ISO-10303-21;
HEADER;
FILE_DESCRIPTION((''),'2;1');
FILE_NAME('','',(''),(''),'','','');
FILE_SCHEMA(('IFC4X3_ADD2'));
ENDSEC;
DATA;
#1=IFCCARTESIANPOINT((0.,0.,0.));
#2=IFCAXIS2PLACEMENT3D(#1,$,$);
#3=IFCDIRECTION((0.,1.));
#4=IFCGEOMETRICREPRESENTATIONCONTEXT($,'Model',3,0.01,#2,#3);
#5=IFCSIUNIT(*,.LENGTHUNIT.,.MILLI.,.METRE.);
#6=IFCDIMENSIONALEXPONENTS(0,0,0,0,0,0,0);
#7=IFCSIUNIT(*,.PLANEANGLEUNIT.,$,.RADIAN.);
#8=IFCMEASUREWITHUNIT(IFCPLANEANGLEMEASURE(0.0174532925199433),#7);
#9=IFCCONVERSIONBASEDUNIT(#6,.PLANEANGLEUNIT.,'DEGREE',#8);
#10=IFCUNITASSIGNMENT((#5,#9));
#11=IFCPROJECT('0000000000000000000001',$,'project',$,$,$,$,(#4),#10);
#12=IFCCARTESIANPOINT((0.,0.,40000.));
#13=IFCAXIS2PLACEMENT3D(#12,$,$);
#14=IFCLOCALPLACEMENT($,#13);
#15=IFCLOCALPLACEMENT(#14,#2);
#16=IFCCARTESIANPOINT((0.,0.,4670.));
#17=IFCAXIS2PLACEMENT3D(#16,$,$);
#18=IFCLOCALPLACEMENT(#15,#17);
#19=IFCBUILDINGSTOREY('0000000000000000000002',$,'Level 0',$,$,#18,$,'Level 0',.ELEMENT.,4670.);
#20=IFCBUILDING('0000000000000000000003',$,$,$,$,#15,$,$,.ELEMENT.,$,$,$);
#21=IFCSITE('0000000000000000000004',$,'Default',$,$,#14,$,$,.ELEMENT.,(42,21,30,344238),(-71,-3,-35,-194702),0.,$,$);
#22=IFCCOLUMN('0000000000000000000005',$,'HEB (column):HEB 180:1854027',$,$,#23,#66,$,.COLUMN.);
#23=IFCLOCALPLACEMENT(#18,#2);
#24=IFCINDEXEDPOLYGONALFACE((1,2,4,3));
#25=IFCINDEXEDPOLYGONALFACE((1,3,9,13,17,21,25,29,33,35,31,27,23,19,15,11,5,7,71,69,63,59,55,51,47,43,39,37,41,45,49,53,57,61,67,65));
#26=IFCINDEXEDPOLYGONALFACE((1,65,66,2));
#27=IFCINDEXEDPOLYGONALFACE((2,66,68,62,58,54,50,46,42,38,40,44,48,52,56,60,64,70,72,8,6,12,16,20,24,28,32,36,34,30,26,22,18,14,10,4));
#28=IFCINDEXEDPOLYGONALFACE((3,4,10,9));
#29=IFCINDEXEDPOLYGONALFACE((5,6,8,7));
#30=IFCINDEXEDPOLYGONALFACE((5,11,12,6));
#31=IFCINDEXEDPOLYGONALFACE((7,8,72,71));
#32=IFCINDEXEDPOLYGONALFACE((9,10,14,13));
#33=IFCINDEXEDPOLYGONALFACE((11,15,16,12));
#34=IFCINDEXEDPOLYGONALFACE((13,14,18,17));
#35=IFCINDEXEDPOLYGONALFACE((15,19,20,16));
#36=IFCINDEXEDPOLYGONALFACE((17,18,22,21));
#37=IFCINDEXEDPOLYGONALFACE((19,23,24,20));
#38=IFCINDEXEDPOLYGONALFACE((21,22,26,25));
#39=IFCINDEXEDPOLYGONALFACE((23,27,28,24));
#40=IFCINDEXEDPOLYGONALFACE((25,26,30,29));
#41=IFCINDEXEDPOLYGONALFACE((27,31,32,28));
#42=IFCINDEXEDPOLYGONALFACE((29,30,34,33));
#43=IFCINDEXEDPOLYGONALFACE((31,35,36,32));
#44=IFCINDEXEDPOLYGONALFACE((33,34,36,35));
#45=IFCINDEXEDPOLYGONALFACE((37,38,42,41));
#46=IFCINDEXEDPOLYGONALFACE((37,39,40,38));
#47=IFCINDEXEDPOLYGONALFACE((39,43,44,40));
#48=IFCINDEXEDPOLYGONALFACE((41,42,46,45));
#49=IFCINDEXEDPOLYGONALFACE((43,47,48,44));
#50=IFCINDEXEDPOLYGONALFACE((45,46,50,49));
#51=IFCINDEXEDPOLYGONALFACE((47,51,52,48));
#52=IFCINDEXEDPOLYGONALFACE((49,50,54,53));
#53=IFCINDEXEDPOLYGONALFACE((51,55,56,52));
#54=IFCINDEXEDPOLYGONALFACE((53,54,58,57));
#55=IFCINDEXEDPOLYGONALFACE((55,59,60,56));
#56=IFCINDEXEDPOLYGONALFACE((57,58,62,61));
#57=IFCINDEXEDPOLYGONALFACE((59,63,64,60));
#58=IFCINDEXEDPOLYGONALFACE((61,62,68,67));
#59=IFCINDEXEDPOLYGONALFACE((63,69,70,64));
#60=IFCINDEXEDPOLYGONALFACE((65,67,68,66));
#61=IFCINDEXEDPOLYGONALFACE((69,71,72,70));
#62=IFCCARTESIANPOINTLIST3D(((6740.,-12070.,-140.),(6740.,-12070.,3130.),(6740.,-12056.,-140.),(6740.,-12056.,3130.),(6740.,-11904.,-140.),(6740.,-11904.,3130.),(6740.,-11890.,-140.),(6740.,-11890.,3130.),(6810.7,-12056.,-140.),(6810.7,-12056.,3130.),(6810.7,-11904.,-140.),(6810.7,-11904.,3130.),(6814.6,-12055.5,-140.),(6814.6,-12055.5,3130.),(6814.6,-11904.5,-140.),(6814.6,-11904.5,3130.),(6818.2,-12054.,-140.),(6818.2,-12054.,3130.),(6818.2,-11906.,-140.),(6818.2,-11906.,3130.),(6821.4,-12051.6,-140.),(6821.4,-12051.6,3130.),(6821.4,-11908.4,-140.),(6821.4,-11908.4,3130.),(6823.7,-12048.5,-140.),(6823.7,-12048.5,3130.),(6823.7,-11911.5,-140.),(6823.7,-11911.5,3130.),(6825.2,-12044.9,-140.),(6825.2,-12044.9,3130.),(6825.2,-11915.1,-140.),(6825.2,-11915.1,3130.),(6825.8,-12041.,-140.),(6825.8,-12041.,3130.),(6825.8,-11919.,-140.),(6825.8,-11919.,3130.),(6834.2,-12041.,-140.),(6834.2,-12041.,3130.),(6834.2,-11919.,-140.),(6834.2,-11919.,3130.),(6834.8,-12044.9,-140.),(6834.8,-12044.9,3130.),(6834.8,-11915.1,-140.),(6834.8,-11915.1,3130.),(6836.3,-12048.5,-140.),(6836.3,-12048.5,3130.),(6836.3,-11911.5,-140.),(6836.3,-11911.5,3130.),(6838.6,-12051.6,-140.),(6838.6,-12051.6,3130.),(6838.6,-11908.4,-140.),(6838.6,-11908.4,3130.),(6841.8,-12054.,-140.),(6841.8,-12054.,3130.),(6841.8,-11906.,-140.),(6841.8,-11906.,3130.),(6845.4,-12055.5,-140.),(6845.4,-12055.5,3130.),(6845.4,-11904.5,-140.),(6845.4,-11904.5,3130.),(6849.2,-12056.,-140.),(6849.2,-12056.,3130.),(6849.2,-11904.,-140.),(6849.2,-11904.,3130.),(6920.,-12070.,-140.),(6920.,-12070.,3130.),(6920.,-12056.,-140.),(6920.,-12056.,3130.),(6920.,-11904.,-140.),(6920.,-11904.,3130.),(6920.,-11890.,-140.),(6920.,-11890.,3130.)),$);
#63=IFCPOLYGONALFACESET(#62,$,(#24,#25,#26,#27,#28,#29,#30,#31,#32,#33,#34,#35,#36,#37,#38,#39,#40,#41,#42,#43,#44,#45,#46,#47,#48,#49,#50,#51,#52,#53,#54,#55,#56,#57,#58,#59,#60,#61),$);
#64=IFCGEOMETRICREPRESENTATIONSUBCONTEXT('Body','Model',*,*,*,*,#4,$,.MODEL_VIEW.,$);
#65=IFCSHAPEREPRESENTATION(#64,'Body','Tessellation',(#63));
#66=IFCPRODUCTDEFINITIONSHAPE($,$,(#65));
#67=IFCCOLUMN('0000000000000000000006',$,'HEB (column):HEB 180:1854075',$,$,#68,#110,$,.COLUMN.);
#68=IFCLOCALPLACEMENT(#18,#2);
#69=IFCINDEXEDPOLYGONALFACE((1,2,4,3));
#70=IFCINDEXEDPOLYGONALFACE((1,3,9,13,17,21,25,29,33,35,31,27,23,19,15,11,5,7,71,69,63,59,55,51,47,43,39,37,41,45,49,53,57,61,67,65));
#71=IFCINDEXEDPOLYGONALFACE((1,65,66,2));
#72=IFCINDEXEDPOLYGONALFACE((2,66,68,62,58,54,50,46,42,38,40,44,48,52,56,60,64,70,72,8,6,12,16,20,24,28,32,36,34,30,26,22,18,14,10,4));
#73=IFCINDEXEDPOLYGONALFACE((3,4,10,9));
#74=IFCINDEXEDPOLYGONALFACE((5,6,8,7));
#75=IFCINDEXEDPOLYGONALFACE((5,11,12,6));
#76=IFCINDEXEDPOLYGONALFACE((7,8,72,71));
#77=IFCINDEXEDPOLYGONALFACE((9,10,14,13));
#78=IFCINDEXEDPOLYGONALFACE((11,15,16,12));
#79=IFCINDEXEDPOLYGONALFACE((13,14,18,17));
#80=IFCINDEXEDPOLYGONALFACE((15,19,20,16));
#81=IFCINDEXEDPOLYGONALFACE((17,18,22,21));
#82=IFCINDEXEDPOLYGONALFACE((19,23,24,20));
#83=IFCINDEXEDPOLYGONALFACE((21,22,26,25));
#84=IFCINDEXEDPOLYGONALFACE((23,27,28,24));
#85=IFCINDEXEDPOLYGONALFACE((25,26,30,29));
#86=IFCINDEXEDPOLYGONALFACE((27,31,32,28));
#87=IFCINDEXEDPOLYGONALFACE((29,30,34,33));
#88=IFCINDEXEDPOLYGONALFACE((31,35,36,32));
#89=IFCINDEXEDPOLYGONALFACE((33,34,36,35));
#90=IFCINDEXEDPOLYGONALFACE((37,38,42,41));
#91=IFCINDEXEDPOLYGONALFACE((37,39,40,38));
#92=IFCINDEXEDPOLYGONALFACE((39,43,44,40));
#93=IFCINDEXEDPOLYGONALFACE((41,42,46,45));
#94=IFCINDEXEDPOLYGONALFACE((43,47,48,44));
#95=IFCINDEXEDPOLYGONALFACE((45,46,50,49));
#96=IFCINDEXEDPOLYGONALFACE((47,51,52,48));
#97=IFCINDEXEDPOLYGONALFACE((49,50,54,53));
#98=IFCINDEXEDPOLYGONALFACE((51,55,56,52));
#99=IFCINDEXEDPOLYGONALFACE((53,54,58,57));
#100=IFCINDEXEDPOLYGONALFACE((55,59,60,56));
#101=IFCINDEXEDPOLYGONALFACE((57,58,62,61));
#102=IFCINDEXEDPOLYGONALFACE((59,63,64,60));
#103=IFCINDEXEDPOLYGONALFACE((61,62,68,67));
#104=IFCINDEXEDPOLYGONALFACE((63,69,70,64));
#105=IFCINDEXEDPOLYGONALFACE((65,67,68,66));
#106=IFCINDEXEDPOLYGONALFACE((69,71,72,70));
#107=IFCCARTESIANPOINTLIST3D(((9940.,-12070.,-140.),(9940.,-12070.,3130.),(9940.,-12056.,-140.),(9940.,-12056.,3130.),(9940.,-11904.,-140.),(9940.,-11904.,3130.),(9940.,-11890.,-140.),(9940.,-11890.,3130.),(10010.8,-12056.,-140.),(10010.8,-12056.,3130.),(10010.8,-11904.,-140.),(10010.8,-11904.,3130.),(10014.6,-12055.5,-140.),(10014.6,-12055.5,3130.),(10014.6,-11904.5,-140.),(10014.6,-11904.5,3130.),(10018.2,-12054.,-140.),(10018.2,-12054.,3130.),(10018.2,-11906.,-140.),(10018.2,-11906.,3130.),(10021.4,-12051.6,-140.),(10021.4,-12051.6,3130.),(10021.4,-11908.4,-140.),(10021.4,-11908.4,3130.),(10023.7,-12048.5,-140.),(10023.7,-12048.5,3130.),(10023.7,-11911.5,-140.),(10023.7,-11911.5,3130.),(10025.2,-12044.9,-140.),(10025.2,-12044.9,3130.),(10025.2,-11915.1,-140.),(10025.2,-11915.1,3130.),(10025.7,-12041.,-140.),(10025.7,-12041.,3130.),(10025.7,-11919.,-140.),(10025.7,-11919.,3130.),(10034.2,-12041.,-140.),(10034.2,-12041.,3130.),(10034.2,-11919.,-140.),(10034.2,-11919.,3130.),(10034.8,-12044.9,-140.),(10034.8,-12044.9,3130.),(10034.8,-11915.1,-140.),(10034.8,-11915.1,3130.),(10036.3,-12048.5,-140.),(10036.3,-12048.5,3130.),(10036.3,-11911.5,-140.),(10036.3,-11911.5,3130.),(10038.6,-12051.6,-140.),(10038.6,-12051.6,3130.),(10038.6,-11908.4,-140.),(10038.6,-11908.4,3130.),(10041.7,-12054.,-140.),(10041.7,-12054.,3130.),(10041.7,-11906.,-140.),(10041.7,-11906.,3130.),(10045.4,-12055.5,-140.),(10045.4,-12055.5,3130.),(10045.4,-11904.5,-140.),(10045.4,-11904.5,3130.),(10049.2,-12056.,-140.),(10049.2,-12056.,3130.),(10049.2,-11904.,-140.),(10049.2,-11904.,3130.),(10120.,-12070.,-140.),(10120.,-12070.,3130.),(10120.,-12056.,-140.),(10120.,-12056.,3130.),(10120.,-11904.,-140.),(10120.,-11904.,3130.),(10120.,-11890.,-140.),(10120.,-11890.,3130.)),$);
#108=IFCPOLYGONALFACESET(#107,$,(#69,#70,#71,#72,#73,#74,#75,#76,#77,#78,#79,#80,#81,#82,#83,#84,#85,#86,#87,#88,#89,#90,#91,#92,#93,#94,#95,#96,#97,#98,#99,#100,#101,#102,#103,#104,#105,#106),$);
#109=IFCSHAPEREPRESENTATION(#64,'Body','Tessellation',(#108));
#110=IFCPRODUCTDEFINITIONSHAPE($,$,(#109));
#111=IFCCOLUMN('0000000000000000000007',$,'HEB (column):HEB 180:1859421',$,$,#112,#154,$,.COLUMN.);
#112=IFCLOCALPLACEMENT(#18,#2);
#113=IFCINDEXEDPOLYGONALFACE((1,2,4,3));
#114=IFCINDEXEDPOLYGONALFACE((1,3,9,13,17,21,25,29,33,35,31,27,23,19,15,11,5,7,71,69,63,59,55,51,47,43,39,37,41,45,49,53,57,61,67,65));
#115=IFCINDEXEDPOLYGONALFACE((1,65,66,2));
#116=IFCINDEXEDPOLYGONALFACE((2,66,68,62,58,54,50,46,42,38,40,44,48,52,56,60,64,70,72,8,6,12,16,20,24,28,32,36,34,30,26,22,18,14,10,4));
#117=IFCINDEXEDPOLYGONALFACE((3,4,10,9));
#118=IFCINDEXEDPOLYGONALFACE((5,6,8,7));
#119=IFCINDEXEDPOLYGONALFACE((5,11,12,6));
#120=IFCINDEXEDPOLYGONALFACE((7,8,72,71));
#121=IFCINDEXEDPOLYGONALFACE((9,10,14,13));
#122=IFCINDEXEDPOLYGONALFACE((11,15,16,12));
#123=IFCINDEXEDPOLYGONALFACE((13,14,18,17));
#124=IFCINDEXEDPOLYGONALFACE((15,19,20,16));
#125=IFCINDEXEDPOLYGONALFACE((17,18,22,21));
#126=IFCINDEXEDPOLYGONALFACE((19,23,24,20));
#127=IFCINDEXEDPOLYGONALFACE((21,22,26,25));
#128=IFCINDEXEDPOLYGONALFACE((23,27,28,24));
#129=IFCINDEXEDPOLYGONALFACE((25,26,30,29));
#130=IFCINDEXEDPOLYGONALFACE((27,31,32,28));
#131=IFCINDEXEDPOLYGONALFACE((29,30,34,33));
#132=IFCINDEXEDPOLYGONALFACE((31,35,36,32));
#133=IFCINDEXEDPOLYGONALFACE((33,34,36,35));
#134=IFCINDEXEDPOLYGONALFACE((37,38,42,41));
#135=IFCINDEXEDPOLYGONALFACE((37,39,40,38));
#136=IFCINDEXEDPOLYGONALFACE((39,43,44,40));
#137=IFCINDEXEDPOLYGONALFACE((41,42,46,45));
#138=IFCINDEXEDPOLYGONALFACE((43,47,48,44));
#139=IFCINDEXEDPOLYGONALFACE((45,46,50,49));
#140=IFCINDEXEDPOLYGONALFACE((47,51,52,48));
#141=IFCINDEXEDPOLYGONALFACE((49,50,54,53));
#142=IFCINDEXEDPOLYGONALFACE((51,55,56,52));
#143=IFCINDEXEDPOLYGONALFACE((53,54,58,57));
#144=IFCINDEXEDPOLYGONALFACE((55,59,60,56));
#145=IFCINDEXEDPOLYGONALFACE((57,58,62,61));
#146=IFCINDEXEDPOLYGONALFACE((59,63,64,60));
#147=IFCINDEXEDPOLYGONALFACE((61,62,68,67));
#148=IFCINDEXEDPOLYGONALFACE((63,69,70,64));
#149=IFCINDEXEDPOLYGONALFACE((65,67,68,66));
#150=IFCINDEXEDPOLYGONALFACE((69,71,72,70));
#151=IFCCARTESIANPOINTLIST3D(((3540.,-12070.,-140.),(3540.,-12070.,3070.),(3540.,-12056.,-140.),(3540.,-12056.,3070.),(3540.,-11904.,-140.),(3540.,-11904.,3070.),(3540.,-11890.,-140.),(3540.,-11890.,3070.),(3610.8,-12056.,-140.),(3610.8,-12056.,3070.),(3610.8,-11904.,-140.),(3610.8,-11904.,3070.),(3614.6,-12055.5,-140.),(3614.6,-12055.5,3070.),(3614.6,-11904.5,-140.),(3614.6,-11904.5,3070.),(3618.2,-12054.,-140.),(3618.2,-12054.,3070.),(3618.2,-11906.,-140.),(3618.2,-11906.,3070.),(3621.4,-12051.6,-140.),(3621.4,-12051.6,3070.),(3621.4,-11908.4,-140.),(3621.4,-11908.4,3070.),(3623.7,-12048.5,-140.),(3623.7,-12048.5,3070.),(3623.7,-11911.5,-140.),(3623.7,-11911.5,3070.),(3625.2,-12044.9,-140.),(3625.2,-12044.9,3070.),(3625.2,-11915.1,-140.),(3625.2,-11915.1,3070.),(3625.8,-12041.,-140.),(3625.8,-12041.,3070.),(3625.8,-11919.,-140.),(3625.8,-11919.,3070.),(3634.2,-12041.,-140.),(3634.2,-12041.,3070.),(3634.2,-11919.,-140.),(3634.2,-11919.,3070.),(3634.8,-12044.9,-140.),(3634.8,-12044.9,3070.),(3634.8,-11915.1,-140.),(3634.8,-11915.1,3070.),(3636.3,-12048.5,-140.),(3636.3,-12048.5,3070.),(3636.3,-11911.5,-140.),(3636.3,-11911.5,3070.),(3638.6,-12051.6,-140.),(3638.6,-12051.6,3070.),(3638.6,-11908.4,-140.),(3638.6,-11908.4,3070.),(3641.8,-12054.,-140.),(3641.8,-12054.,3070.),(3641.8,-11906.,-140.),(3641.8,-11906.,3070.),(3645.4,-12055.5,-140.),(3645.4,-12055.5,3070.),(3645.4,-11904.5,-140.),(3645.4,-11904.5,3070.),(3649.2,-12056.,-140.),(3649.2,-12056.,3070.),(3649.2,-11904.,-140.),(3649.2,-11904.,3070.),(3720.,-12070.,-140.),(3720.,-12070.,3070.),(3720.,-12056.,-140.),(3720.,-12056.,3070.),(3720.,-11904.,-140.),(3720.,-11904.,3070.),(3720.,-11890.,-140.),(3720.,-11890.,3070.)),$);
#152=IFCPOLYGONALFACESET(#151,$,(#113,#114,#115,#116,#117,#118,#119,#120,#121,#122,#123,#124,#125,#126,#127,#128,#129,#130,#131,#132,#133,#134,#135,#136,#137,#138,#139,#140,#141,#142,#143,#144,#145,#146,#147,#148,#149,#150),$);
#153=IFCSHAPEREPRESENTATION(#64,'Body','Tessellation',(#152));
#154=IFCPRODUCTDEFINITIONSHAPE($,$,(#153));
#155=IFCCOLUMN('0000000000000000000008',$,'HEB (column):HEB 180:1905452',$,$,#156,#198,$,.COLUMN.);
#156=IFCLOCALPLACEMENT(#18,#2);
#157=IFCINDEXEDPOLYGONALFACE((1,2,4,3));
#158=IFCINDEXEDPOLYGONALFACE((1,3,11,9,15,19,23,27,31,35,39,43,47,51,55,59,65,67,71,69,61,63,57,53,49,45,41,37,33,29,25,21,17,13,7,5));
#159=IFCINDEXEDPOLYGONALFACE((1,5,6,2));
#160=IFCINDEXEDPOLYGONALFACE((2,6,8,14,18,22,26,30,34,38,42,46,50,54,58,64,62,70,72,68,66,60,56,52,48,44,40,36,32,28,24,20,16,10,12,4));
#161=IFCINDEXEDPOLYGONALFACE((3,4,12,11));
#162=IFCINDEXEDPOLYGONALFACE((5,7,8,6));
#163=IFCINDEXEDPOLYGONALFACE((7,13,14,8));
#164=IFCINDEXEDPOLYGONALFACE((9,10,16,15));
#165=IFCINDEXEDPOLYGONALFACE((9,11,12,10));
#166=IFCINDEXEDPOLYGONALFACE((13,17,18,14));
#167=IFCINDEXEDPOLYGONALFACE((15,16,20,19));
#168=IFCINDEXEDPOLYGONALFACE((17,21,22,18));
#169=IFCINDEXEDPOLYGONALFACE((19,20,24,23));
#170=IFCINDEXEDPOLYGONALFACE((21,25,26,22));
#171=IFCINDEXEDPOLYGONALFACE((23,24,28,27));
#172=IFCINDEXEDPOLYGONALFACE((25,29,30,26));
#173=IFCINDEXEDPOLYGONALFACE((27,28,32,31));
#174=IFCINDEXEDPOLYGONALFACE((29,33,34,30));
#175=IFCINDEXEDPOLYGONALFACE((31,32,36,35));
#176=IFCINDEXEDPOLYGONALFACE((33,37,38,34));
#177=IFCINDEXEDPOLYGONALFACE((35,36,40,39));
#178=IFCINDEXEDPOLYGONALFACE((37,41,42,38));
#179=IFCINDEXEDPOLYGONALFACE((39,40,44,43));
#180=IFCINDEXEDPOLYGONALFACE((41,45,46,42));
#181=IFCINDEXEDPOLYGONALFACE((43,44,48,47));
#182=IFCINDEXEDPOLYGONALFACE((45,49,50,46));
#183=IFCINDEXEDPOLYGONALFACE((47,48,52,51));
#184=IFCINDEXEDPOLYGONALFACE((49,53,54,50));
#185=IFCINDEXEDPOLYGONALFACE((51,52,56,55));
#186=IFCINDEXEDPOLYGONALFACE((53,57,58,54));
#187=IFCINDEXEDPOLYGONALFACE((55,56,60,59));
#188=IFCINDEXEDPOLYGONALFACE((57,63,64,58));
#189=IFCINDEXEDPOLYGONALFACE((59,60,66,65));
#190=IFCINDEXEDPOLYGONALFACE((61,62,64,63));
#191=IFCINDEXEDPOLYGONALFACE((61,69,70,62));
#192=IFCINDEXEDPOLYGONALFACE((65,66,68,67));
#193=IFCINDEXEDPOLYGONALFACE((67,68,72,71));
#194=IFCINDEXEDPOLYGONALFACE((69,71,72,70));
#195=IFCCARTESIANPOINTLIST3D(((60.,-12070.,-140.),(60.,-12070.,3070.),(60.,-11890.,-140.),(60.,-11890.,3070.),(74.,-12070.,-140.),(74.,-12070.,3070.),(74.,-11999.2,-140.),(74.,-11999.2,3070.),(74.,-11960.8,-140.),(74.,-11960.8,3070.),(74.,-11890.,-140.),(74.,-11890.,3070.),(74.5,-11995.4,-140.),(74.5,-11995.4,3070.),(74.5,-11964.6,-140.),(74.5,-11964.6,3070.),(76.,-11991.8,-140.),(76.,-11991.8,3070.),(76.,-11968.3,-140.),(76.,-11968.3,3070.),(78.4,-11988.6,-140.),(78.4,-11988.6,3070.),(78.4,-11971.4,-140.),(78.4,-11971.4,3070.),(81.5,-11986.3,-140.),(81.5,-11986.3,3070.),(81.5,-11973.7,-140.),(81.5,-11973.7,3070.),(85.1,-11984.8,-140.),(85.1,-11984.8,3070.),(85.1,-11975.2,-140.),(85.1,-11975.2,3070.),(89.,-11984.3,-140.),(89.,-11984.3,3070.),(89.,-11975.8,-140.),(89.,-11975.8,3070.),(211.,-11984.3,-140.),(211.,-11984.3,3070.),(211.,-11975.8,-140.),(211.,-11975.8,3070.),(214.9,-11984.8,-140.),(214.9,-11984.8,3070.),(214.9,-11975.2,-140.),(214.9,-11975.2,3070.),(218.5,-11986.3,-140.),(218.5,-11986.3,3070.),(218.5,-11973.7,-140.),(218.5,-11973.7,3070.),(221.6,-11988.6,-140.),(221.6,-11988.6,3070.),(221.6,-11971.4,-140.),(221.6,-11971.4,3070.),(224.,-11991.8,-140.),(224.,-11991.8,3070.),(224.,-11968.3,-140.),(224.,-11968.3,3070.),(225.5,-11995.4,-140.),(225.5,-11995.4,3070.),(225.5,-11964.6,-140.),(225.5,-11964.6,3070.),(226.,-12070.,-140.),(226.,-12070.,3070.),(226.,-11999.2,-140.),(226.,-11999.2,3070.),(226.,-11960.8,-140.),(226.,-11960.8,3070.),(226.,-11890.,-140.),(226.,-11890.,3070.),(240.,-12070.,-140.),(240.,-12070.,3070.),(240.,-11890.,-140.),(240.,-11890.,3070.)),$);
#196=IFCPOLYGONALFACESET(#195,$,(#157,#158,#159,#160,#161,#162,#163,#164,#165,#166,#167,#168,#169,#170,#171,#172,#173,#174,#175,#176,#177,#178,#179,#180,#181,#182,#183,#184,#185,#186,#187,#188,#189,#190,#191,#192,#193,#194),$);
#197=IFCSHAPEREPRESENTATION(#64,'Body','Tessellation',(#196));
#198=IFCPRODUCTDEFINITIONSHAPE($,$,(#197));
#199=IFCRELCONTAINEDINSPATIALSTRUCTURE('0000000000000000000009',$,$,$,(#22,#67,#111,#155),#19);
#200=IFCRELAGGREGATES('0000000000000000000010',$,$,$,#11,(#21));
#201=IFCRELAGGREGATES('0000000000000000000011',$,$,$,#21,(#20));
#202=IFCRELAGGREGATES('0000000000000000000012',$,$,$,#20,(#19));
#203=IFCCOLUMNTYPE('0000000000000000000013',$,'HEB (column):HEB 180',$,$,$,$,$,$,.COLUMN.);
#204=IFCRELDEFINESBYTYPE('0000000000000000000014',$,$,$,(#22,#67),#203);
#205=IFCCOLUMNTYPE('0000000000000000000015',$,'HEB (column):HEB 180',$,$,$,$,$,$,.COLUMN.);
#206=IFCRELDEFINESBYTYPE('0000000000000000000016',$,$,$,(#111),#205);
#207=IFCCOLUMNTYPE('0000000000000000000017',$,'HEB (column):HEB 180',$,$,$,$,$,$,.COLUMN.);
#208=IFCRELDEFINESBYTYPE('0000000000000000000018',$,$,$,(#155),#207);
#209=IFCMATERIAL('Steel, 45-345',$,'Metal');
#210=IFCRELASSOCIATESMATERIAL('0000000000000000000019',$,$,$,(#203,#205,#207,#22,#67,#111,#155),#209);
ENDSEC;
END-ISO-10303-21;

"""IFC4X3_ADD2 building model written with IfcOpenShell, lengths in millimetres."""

from ifc_helpers import new_model, entity, si_unit, converted_unit, direction, frame, origin, origin_2d_with_axis, place, context, subcontext, project, spatial, i_section, extrude, source, transform, mapped, material, material_profile, profile_set, profile_usage, type_object, type_shapes, element, save


model = new_model("IFC4X3_ADD2")

# Units and contexts
model_context = context("Model", 3, precision=0.01, world=origin(), true_north=direction((0.0, 1.0)))
body_context = subcontext(model_context, "Body", "Model", "MODEL_VIEW")
ifc_project = project(units=[si_unit("LENGTHUNIT", "METRE", prefix="MILLI"), converted_unit("PLANEANGLEUNIT", "DEGREE", entity("IfcPlaneAngleMeasure", 0.0174532925199433), si_unit("PLANEANGLEUNIT", "RADIAN"), dimensions=[0, 0, 0, 0, 0, 0, 0])], contexts=[model_context])

# Site, building, storey
site_placement = place(None, frame((0.0, 0.0, 40000.0)))
site = spatial("IfcSite", under=ifc_project, at=site_placement, Name="Default", CompositionType="ELEMENT", RefLatitude=(42, 21, 30, 344238), RefLongitude=(-71, -3, -35, -194702), RefElevation=0.0)
building_placement = place(site_placement, origin())
building = spatial("IfcBuilding", under=site, at=building_placement, CompositionType="ELEMENT")
storey_placement = place(building_placement, frame((0.0, 0.0, 4670.0)))
storey = spatial("IfcBuildingStorey", under=building, at=storey_placement, Name="Level 0", LongName="Level 0", CompositionType="ELEMENT", Elevation=4670.0)

# Columns
ifc_material_1 = material(Name="Steel, 45-345", Category="Metal")
ifc_material_profile_1 = material_profile(ifc_material_1, i_section(OverallWidth=180.0, OverallDepth=180.0, WebThickness=8.5, FlangeThickness=14.0, FilletRadius=15.0, at=origin_2d_with_axis()), Name="HEB 180")
ifc_profile_set_1 = profile_set([ifc_material_profile_1], Name="HEB 180")
ifc_profile_usage_1 = profile_usage(ifc_profile_set_1)
column_type_1 = type_object("IfcColumnType", Name="HEB (column):HEB 180", PredefinedType="COLUMN", material=ifc_profile_set_1)
shared_shape_1 = source(origin(), body_context, "Body", "SweptSolid", [
    extrude(i_section(OverallWidth=180.0, OverallDepth=180.0, WebThickness=8.5, FlangeThickness=14.0, FilletRadius=15.0, at=origin_2d_with_axis()), frame((0.0, 0.0, 4530.0), z_axis=(0.0, 0.0, 1.0), x_axis=(-1.0, 0.0, 0.0)), (0.0, 0.0, 1.0), 3270.0),
])
type_shapes(column_type_1, [shared_shape_1])
for number, where, name in (
    (1, (6830.0, -11980.0, -4670.0), "HEB (column):HEB 180:1854027"),
    (2, (10030.0, -11980.0, -4670.0), "HEB (column):HEB 180:1854075"),
):
    element("IfcColumn", number, at=place(storey_placement, frame(where)), inside=storey, type_object=column_type_1, material=ifc_profile_usage_1, Name=name, PredefinedType="COLUMN", context=body_context, shape_type="MappedRepresentation", body=[
        mapped(shared_shape_1, transform((0.0, 0.0, 0.0), scale=1.0)),
    ])
column_type_2 = type_object("IfcColumnType", Name="HEB (column):HEB 180", PredefinedType="COLUMN", material=ifc_profile_set_1)
shared_shape_2 = source(origin(), body_context, "Body", "SweptSolid", [
    extrude(i_section(OverallWidth=180.0, OverallDepth=180.0, WebThickness=8.5, FlangeThickness=14.0, FilletRadius=15.0, at=origin_2d_with_axis()), frame((0.0, 0.0, 4530.0), z_axis=(0.0, 0.0, 1.0), x_axis=(-1.0, 0.0, 0.0)), (0.0, 0.0, 1.0), 3210.0),
])
type_shapes(column_type_2, [shared_shape_2])
column_1_placement = place(storey_placement, frame((3630.0, -11980.0, -4670.0)))
element("IfcColumn", 3, at=column_1_placement, inside=storey, type_object=column_type_2, material=ifc_profile_usage_1, Name="HEB (column):HEB 180:1859421", PredefinedType="COLUMN", context=body_context, shape_type="MappedRepresentation", body=[
    mapped(shared_shape_2, transform((0.0, 0.0, 0.0), scale=1.0)),
])
column_type_3 = type_object("IfcColumnType", Name="HEB (column):HEB 180", PredefinedType="COLUMN", material=ifc_profile_set_1)
shared_shape_3 = source(origin(), body_context, "Body", "SweptSolid", [
    extrude(i_section(OverallWidth=180.0, OverallDepth=180.0, WebThickness=8.5, FlangeThickness=14.0, FilletRadius=15.0, at=origin_2d_with_axis()), frame((0.0, 0.0, 4530.0), z_axis=(0.0, 0.0, 1.0), x_axis=(-1.0, 0.0, 0.0)), (0.0, 0.0, 1.0), 3210.0),
])
type_shapes(column_type_3, [shared_shape_3])
column_2_placement = place(storey_placement, frame((150.0, -11980.0, -4670.0), z_axis=(0.0, 0.0, 1.0), x_axis=(0.0, 1.0, 0.0)))
element("IfcColumn", 4, at=column_2_placement, inside=storey, type_object=column_type_3, material=ifc_profile_usage_1, Name="HEB (column):HEB 180:1905452", PredefinedType="COLUMN", context=body_context, shape_type="MappedRepresentation", body=[
    mapped(shared_shape_3, transform((0.0, 0.0, 0.0), scale=1.0)),
])

save(model, "model.ifc")
